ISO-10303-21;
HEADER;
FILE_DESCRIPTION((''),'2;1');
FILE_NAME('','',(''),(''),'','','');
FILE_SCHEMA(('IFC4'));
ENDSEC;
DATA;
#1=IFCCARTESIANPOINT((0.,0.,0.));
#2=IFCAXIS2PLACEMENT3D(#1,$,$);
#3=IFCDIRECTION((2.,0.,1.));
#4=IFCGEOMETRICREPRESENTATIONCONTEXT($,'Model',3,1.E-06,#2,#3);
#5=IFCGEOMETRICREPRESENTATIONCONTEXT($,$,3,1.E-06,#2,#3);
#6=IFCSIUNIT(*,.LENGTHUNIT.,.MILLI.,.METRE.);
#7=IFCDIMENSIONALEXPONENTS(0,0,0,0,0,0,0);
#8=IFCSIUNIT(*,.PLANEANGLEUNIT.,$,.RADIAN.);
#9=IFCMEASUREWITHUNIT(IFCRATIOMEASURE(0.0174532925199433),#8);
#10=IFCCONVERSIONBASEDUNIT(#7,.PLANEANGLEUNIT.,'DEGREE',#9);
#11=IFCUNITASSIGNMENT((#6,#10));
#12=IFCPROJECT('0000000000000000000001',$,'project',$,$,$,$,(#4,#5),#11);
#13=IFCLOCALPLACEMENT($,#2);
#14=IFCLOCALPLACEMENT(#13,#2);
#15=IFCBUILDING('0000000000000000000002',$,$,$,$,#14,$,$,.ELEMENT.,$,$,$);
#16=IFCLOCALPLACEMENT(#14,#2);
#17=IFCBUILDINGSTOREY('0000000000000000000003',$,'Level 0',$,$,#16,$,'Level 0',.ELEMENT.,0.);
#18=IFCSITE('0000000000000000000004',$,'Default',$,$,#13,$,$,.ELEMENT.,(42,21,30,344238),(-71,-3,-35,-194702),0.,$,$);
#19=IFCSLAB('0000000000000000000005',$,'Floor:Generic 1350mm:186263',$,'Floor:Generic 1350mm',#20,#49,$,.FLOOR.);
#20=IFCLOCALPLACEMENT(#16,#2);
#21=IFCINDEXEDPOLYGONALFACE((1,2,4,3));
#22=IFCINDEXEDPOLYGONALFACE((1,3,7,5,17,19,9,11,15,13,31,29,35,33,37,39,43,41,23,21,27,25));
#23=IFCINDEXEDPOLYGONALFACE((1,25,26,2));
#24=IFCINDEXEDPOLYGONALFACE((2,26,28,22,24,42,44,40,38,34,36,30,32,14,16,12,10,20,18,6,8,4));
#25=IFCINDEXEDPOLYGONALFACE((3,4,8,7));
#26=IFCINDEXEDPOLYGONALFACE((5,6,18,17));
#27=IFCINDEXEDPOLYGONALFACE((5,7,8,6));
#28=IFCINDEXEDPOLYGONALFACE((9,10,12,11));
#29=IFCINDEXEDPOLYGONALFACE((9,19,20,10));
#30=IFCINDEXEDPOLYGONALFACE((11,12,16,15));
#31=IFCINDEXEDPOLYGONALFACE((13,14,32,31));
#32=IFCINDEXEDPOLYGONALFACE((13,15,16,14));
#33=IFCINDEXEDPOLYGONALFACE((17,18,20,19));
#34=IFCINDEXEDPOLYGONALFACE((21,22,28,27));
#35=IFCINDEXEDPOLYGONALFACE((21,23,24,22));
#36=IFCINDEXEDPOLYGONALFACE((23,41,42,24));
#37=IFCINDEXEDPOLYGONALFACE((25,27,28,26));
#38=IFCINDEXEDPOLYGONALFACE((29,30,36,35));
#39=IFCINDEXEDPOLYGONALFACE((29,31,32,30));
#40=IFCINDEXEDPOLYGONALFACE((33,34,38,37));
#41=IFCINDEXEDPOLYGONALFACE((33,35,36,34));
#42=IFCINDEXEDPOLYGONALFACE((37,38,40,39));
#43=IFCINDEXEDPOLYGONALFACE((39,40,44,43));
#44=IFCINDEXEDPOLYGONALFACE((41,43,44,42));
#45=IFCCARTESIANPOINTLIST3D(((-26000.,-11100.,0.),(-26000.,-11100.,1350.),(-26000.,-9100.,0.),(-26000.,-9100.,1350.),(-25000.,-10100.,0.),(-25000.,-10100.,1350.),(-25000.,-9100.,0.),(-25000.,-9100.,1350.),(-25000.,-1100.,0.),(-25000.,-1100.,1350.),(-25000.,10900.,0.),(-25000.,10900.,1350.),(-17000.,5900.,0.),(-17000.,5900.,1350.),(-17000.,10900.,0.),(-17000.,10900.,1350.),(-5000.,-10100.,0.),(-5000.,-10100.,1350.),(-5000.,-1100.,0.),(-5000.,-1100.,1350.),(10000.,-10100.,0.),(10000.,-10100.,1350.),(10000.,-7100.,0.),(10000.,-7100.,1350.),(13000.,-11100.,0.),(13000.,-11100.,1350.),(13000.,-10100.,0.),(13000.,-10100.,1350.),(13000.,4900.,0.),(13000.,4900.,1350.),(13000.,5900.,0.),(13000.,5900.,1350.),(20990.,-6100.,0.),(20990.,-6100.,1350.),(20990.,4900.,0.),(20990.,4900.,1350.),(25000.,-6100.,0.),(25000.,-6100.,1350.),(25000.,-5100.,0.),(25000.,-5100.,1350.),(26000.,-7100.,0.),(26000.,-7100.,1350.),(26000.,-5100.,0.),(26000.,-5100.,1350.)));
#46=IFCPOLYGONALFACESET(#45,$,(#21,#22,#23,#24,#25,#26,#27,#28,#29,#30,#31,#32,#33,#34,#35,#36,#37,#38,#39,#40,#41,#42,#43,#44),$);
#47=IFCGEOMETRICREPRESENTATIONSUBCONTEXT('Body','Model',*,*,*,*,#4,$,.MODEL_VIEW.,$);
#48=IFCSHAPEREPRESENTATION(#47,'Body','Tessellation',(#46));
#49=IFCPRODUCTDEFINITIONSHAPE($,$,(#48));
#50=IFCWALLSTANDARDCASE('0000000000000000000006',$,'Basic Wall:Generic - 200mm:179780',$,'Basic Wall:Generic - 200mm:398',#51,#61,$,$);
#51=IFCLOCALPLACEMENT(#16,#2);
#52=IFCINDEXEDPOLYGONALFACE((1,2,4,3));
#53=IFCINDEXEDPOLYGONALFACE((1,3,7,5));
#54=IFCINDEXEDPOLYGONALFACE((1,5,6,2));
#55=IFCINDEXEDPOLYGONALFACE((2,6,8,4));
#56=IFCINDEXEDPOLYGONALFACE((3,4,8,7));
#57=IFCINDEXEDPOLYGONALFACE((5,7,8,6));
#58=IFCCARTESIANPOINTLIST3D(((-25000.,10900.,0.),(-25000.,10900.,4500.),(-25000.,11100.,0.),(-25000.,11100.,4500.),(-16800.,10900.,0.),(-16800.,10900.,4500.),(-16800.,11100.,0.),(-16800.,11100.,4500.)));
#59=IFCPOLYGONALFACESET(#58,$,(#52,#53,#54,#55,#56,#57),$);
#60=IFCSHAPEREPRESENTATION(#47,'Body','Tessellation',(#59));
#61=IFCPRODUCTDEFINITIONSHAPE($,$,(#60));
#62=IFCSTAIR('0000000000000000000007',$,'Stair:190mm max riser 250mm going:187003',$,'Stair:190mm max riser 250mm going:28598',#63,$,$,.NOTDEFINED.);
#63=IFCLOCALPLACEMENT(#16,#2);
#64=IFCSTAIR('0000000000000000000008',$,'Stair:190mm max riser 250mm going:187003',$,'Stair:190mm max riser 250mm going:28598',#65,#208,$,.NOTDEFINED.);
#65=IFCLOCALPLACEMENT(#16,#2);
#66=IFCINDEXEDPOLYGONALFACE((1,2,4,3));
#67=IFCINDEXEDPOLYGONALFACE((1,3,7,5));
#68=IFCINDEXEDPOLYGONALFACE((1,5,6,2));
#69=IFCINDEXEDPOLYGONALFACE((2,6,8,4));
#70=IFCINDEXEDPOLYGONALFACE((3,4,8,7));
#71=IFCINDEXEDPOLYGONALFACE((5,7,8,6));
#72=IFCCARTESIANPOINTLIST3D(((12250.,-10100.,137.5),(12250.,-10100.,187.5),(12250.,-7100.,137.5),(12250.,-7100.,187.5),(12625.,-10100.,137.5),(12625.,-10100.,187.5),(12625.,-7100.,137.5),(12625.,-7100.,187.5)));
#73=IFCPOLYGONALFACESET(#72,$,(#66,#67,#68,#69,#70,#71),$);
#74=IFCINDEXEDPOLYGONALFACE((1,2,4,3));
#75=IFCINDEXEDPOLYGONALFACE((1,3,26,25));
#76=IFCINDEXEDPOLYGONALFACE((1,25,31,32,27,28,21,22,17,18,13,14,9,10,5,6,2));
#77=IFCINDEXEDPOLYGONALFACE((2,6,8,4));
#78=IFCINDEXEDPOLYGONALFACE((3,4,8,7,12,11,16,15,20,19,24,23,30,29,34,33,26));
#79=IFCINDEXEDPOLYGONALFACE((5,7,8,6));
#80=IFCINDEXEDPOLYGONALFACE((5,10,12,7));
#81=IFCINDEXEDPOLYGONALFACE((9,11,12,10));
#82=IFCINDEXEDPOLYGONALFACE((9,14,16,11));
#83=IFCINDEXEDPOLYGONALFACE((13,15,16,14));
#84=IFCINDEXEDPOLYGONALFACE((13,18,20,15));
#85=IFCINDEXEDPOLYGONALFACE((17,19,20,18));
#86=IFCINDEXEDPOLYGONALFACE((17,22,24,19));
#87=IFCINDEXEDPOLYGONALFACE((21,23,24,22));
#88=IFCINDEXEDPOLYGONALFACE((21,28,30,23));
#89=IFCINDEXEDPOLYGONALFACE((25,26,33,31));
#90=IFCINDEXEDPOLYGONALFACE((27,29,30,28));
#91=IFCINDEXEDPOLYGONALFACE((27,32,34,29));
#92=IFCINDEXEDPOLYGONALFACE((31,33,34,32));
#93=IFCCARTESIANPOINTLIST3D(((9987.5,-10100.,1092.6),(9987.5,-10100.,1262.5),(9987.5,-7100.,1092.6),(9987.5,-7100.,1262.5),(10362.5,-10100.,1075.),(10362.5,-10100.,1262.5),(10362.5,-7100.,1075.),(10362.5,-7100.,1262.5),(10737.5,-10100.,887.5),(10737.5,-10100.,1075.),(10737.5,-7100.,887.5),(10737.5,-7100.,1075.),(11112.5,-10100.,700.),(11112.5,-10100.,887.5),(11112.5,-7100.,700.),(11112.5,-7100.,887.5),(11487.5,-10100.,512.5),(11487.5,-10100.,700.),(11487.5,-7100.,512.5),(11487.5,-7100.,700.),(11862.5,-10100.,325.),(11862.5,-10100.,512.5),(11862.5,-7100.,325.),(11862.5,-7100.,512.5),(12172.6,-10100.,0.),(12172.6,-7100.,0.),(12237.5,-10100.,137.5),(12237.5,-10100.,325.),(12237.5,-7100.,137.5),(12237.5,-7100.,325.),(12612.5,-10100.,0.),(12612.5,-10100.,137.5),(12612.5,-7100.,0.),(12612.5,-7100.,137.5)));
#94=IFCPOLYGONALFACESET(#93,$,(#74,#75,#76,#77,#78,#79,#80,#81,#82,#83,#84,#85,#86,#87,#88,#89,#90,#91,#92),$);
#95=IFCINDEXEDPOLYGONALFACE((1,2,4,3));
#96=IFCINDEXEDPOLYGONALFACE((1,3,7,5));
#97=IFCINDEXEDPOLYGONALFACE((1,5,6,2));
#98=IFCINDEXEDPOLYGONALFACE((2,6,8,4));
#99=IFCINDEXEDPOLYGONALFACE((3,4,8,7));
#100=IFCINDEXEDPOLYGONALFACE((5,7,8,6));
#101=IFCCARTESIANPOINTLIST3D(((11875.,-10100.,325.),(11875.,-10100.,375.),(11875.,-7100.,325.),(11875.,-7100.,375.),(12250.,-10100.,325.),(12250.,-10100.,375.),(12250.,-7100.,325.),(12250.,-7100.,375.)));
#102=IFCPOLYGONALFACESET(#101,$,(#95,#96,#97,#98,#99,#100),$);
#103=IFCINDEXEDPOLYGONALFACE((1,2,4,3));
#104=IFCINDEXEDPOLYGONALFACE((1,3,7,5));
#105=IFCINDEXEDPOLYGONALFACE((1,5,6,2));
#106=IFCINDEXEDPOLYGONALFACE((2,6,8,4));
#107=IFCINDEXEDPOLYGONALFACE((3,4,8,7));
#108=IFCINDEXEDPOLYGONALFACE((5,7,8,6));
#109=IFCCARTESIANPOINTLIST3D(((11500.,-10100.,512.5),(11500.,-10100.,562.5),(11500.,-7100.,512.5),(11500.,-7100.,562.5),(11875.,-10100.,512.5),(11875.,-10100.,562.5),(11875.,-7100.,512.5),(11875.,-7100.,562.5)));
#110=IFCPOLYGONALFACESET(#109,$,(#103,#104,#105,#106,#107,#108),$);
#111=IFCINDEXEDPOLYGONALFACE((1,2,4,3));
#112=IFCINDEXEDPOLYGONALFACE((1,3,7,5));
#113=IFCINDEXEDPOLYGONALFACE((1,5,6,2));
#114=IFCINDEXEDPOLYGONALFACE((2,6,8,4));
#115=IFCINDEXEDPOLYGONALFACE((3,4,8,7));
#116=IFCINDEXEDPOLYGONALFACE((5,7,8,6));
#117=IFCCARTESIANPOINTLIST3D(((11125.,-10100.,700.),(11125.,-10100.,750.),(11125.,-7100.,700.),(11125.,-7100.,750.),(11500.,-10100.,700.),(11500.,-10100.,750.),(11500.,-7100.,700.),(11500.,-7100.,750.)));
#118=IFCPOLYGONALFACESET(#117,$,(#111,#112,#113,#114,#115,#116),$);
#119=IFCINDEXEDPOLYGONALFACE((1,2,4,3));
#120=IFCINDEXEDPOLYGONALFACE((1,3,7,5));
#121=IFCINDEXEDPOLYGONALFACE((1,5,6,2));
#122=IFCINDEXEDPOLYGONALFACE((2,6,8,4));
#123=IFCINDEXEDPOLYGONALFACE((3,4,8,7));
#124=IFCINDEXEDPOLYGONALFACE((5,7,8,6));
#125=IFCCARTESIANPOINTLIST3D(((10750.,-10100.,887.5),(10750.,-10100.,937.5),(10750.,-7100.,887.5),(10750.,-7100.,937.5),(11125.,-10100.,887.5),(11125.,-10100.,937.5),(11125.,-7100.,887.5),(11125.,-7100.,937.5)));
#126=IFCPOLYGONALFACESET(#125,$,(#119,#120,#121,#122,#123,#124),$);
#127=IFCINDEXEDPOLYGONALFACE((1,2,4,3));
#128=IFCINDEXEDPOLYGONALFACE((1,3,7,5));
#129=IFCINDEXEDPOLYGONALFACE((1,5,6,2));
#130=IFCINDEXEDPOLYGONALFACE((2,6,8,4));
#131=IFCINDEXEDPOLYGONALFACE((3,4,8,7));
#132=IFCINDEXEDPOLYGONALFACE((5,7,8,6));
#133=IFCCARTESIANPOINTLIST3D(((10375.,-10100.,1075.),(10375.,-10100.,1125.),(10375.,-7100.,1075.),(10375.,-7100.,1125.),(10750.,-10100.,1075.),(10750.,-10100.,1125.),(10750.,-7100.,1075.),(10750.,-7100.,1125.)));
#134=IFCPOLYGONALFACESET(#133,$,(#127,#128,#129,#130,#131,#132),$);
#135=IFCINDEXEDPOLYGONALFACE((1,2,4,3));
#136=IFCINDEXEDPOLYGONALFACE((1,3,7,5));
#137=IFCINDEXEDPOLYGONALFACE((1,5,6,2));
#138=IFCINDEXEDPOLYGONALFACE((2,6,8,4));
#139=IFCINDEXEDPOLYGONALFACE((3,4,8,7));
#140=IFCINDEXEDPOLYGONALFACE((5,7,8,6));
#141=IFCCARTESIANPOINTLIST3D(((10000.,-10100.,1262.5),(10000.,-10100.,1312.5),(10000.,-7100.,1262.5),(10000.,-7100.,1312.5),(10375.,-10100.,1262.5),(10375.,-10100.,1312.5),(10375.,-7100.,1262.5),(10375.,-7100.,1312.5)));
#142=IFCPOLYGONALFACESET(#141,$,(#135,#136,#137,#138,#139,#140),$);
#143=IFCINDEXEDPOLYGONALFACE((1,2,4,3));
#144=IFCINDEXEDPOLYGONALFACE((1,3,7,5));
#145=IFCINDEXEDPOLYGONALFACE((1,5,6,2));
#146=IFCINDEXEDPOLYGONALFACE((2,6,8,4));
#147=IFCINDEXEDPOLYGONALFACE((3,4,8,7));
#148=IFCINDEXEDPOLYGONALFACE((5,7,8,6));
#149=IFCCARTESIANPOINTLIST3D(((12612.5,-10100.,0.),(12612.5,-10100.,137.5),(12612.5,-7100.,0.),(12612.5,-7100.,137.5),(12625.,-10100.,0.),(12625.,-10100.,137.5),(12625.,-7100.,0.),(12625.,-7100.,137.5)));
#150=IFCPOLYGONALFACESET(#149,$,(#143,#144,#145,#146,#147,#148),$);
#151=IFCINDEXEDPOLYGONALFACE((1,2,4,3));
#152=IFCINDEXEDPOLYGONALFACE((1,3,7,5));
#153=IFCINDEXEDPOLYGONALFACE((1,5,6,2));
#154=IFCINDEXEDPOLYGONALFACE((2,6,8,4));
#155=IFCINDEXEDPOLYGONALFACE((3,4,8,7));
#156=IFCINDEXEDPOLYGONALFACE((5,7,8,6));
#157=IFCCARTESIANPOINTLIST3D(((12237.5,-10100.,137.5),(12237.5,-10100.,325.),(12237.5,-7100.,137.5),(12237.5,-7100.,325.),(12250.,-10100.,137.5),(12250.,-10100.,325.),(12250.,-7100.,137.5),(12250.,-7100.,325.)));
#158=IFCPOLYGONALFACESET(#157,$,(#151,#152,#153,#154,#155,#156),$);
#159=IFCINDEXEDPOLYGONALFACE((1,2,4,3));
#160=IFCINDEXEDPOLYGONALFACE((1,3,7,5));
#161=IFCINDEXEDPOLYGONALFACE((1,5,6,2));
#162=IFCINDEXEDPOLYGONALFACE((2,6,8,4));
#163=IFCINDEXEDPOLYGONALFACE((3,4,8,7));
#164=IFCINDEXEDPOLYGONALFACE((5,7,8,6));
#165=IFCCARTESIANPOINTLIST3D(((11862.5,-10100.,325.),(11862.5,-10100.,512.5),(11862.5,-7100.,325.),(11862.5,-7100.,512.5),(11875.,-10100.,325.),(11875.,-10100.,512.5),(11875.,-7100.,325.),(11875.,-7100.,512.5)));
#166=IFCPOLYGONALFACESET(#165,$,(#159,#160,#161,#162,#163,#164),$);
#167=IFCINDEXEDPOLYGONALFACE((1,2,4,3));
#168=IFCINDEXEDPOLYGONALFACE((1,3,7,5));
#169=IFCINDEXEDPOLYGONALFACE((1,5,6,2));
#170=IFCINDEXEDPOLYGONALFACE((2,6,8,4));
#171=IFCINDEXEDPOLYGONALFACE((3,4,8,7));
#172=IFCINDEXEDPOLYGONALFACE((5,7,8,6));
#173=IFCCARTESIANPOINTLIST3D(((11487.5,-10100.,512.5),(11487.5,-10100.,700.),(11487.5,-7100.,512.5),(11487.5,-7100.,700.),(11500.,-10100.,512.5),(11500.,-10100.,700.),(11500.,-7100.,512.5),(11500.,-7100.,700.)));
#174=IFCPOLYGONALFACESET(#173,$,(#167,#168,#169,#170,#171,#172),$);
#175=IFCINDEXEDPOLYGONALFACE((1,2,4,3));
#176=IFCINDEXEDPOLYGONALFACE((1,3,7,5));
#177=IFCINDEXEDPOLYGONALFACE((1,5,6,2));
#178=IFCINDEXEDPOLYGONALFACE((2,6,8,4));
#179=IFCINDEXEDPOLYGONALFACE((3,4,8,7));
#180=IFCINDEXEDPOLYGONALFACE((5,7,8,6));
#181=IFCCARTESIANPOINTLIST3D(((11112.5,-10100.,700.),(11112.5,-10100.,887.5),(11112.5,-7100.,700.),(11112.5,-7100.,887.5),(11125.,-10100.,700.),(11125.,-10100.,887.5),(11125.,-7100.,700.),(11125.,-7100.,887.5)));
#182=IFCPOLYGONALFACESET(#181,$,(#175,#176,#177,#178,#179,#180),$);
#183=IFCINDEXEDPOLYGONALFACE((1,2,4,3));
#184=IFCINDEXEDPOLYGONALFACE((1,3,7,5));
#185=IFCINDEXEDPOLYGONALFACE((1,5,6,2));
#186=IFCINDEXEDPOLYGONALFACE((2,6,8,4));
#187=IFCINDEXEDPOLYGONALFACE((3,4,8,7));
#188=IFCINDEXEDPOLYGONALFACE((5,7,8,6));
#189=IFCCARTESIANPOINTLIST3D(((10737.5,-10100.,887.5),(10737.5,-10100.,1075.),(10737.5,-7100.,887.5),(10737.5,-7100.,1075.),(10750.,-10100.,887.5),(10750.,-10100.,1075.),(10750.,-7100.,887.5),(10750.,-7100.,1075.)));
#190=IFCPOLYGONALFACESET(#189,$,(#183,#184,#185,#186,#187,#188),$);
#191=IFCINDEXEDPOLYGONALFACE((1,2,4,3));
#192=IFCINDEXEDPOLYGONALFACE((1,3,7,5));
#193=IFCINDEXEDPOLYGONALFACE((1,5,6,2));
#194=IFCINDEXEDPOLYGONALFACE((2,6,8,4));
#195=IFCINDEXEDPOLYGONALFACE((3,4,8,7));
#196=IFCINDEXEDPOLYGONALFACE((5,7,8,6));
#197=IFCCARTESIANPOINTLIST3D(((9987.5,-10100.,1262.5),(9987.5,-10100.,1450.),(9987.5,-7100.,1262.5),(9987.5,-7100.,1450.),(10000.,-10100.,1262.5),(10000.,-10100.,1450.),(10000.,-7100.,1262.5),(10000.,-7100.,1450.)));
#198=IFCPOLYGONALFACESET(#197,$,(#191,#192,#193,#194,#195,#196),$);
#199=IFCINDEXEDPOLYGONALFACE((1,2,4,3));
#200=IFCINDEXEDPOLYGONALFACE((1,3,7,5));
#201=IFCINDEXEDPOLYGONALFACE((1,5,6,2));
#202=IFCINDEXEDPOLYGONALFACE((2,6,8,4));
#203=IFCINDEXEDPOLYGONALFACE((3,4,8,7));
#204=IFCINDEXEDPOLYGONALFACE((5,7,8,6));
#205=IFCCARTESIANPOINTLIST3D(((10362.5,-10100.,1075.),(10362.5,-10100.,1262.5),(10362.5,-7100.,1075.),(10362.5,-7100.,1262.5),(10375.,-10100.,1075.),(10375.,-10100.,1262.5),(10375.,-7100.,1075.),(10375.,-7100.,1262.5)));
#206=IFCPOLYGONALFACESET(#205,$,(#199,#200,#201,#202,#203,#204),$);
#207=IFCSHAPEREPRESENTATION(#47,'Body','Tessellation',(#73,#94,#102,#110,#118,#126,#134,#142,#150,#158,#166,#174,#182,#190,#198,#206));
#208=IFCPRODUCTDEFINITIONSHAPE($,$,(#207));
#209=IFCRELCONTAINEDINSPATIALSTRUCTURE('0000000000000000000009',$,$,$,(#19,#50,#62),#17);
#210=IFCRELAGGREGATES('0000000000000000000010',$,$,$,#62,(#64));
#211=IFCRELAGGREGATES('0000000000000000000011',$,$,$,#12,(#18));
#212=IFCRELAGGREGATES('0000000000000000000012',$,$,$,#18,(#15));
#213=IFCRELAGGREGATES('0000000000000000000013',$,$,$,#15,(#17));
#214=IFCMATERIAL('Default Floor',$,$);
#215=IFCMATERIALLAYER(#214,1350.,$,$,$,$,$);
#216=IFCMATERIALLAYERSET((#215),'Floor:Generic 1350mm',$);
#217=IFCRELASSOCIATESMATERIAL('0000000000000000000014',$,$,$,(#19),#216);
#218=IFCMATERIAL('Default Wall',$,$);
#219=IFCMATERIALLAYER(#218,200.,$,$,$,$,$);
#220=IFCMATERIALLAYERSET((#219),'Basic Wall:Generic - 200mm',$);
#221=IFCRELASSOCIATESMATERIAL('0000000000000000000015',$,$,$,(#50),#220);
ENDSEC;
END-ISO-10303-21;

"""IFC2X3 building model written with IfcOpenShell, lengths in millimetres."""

from ifc_helpers import new_model, entity, si_unit, converted_unit, direction, frame, frame_2d, origin, place, context, subcontext, project, spatial, polyline, rectangle, outline, extrude, material, layer, layer_set, layer_usage, element, aggregate, save


model = new_model("IFC2X3")

# Units and contexts
model_context = context("Model", 3, precision=1e-06, world=origin(), true_north=direction((2.0, 0.0, 1.0)))
context_of_model = context(None, 3, precision=1e-06, world=origin(), true_north=direction((2.0, 0.0, 1.0)))
body_context = subcontext(model_context, "Body", "Model", "MODEL_VIEW")
ifc_project = project(units=[si_unit("LENGTHUNIT", "METRE", prefix="MILLI"), converted_unit("PLANEANGLEUNIT", "DEGREE", entity("IfcRatioMeasure", 0.0174532925199433), si_unit("PLANEANGLEUNIT", "RADIAN"), dimensions=[0, 0, 0, 0, 0, 0, 0])], contexts=[model_context, context_of_model])

# Site, building, storey
site_placement = place(None, origin())
site = spatial("IfcSite", under=ifc_project, at=site_placement, Name="Default", CompositionType="ELEMENT", RefLatitude=(42, 21, 30, 344238), RefLongitude=(-71, -3, -35, -194702), RefElevation=0.0)
building_placement = place(site_placement, origin())
building = spatial("IfcBuilding", under=site, at=building_placement, CompositionType="ELEMENT")
storey_placement = place(building_placement, origin())
storey = spatial("IfcBuildingStorey", under=building, at=storey_placement, Name="Level 0", LongName="Level 0", CompositionType="ELEMENT", Elevation=0.0)

# Slab
ifc_material_1 = material(Name="Default Floor")
ifc_layer_1 = layer(ifc_material_1, 1350.0)
ifc_layer_set_1 = layer_set([ifc_layer_1], Name="Floor:Generic 1350mm")
ifc_layer_usage_1 = layer_usage(ifc_layer_set_1, "AXIS3", "POSITIVE", 0.0)
slab_placement = place(storey_placement, origin())
element("IfcSlab", 1, at=slab_placement, inside=storey, material=ifc_layer_usage_1, Name="Floor:Generic 1350mm:186263", ObjectType="Floor:Generic 1350mm", PredefinedType="FLOOR", context=body_context, shape_type="SweptSolid", body=[
    extrude(outline(polyline([(26000.0, -9000.0), (25000.0, -9000.0), (25000.0, -10000.0), (5000.0, -10000.0), (5000.0, -1000.0), (25000.0, -1000.0), (25000.0, 11000.0), (17000.0, 11000.0), (17000.0, 6000.0), (-13000.0, 6000.0), (-13000.0, 5000.0), (-20990.0, 5000.0), (-20990.0, -6000.0), (-25000.0, -6000.0), (-25000.0, -5000.0), (-26000.0, -5000.0), (-26000.0, -7000.0), (-10000.0, -7000.0), (-10000.0, -10000.0), (-13000.0, -10000.0), (-13000.0, -11000.0), (26000.0, -11000.0), (26000.0, -9000.0)])), frame((0.0, -100.0, 1350.0), z_axis=(0.0, 0.0, -1.0), x_axis=(-1.0, 0.0, 0.0)), (0.0, 0.0, 1.0), 1350.0),
])

# Shared definitions
ifc_material_2 = material(Name="Default Wall")
ifc_layer_2 = layer(ifc_material_2, 200.0)
ifc_layer_set_2 = layer_set([ifc_layer_2], Name="Basic Wall:Generic - 200mm")

# Wall
ifc_layer_usage_2 = layer_usage(ifc_layer_set_2, "AXIS2", "NEGATIVE", 100.0)
wall_1_placement = place(storey_placement, frame((-25000.0, 11000.0, 0.0)))
element("IfcWallStandardCase", 2, at=wall_1_placement, inside=storey, material=ifc_layer_usage_2, Name="Basic Wall:Generic - 200mm:179780", ObjectType="Basic Wall:Generic - 200mm:398", context=body_context, shape_type="SweptSolid", body=[
    extrude(rectangle(XDim=8200.0, YDim=200.0, at=frame_2d((4100.0, 0.0), x_axis=(-1.0, 0.0))), origin(), (0.0, 0.0, 1.0), 4500.0),
])

# Stairs
placement = place(storey_placement, origin())
stair_1 = element("IfcStair", 3, at=placement, inside=storey, Name="Stair:190mm max riser 250mm going:187003", ObjectType="Stair:190mm max riser 250mm going:28598", ShapeType="NOTDEFINED")
stair_2 = element("IfcStair", 4, at=placement, Name="Stair:190mm max riser 250mm going:187003", ObjectType="Stair:190mm max riser 250mm going:28598", ShapeType="NOTDEFINED", context=body_context, shape_type="SweptSolid", body=[
    extrude(rectangle(XDim=375.0, YDim=3000.0, at=frame_2d((0.0, 0.0), x_axis=(1.0, 0.0))), frame((12437.5, -8600.0, 137.5)), (0.0, 0.0, 1.0), 50.0),
    extrude(outline(polyline([(503.2, -1261.2), (640.7, -1261.2), (640.7, -821.3), (-451.8, 1363.8), (-621.8, 1363.8), (-621.8, 988.8), (-434.3, 988.8), (-434.3, 613.8), (-246.8, 613.8), (-246.8, 238.8), (-59.3, 238.8), (-59.3, -136.2), (128.2, -136.2), (128.2, -511.2), (315.7, -511.2), (315.7, -886.2), (503.2, -886.2), (503.2, -1261.2)])), frame((11351.3, -10100.0, 640.7), z_axis=(0.0, 1.0, 0.0), x_axis=(0.0, 0.0, -1.0)), (0.0, 0.0, 1.0), 3000.0),
    extrude(rectangle(XDim=375.0, YDim=3000.0, at=frame_2d((0.0, 0.0), x_axis=(1.0, 0.0))), frame((12062.5, -8600.0, 325.0)), (0.0, 0.0, 1.0), 50.0),
    extrude(rectangle(XDim=375.0, YDim=3000.0, at=frame_2d((0.0, 0.0), x_axis=(1.0, 0.0))), frame((11687.5, -8600.0, 512.5)), (0.0, 0.0, 1.0), 50.0),
    extrude(rectangle(XDim=375.0, YDim=3000.0, at=frame_2d((0.0, 0.0), x_axis=(1.0, 0.0))), frame((11312.5, -8600.0, 700.0)), (0.0, 0.0, 1.0), 50.0),
    extrude(rectangle(XDim=375.0, YDim=3000.0, at=frame_2d((0.0, 0.0), x_axis=(1.0, 0.0))), frame((10937.5, -8600.0, 887.5)), (0.0, 0.0, 1.0), 50.0),
    extrude(rectangle(XDim=375.0, YDim=3000.0, at=frame_2d((0.0, 0.0), x_axis=(1.0, 0.0))), frame((10562.5, -8600.0, 1075.0)), (0.0, 0.0, 1.0), 50.0),
    extrude(rectangle(XDim=375.0, YDim=3000.0, at=frame_2d((0.0, 0.0), x_axis=(1.0, 0.0))), frame((10187.5, -8600.0, 1262.5)), (0.0, 0.0, 1.0), 50.0),
    extrude(rectangle(XDim=3000.0, YDim=12.5, at=frame_2d((0.0, 0.0), x_axis=(1.0, 0.0))), frame((12618.8, -8600.0, 0.0), z_axis=(0.0, 0.0, 1.0), x_axis=(0.0, -1.0, 0.0)), (0.0, 0.0, 1.0), 137.5),
    extrude(rectangle(XDim=3000.0, YDim=12.5, at=frame_2d((0.0, 0.0), x_axis=(1.0, 0.0))), frame((12243.8, -8600.0, 137.5), z_axis=(0.0, 0.0, 1.0), x_axis=(0.0, -1.0, 0.0)), (0.0, 0.0, 1.0), 187.5),
    extrude(rectangle(XDim=3000.0, YDim=12.5, at=frame_2d((0.0, 0.0), x_axis=(1.0, 0.0))), frame((11868.8, -8600.0, 325.0), z_axis=(0.0, 0.0, 1.0), x_axis=(0.0, -1.0, 0.0)), (0.0, 0.0, 1.0), 187.5),
    extrude(rectangle(XDim=3000.0, YDim=12.5, at=frame_2d((0.0, 0.0), x_axis=(1.0, 0.0))), frame((11493.8, -8600.0, 512.5), z_axis=(0.0, 0.0, 1.0), x_axis=(0.0, -1.0, 0.0)), (0.0, 0.0, 1.0), 187.5),
    extrude(rectangle(XDim=3000.0, YDim=12.5, at=frame_2d((0.0, 0.0), x_axis=(1.0, 0.0))), frame((11118.8, -8600.0, 700.0), z_axis=(0.0, 0.0, 1.0), x_axis=(0.0, -1.0, 0.0)), (0.0, 0.0, 1.0), 187.5),
    extrude(rectangle(XDim=3000.0, YDim=12.5, at=frame_2d((0.0, 0.0), x_axis=(1.0, 0.0))), frame((10743.8, -8600.0, 887.5), z_axis=(0.0, 0.0, 1.0), x_axis=(0.0, -1.0, 0.0)), (0.0, 0.0, 1.0), 187.5),
    extrude(rectangle(XDim=3000.0, YDim=12.5, at=frame_2d((0.0, 0.0), x_axis=(1.0, 0.0))), frame((9993.8, -8600.0, 1262.5), z_axis=(0.0, 0.0, 1.0), x_axis=(0.0, -1.0, 0.0)), (0.0, 0.0, 1.0), 187.5),
    extrude(rectangle(XDim=3000.0, YDim=12.5, at=frame_2d((0.0, 0.0), x_axis=(1.0, 0.0))), frame((10368.8, -8600.0, 1075.0), z_axis=(0.0, 0.0, 1.0), x_axis=(0.0, -1.0, 0.0)), (0.0, 0.0, 1.0), 187.5),
])
aggregate(stair_1, [stair_2])

save(model, "model.ifc")
